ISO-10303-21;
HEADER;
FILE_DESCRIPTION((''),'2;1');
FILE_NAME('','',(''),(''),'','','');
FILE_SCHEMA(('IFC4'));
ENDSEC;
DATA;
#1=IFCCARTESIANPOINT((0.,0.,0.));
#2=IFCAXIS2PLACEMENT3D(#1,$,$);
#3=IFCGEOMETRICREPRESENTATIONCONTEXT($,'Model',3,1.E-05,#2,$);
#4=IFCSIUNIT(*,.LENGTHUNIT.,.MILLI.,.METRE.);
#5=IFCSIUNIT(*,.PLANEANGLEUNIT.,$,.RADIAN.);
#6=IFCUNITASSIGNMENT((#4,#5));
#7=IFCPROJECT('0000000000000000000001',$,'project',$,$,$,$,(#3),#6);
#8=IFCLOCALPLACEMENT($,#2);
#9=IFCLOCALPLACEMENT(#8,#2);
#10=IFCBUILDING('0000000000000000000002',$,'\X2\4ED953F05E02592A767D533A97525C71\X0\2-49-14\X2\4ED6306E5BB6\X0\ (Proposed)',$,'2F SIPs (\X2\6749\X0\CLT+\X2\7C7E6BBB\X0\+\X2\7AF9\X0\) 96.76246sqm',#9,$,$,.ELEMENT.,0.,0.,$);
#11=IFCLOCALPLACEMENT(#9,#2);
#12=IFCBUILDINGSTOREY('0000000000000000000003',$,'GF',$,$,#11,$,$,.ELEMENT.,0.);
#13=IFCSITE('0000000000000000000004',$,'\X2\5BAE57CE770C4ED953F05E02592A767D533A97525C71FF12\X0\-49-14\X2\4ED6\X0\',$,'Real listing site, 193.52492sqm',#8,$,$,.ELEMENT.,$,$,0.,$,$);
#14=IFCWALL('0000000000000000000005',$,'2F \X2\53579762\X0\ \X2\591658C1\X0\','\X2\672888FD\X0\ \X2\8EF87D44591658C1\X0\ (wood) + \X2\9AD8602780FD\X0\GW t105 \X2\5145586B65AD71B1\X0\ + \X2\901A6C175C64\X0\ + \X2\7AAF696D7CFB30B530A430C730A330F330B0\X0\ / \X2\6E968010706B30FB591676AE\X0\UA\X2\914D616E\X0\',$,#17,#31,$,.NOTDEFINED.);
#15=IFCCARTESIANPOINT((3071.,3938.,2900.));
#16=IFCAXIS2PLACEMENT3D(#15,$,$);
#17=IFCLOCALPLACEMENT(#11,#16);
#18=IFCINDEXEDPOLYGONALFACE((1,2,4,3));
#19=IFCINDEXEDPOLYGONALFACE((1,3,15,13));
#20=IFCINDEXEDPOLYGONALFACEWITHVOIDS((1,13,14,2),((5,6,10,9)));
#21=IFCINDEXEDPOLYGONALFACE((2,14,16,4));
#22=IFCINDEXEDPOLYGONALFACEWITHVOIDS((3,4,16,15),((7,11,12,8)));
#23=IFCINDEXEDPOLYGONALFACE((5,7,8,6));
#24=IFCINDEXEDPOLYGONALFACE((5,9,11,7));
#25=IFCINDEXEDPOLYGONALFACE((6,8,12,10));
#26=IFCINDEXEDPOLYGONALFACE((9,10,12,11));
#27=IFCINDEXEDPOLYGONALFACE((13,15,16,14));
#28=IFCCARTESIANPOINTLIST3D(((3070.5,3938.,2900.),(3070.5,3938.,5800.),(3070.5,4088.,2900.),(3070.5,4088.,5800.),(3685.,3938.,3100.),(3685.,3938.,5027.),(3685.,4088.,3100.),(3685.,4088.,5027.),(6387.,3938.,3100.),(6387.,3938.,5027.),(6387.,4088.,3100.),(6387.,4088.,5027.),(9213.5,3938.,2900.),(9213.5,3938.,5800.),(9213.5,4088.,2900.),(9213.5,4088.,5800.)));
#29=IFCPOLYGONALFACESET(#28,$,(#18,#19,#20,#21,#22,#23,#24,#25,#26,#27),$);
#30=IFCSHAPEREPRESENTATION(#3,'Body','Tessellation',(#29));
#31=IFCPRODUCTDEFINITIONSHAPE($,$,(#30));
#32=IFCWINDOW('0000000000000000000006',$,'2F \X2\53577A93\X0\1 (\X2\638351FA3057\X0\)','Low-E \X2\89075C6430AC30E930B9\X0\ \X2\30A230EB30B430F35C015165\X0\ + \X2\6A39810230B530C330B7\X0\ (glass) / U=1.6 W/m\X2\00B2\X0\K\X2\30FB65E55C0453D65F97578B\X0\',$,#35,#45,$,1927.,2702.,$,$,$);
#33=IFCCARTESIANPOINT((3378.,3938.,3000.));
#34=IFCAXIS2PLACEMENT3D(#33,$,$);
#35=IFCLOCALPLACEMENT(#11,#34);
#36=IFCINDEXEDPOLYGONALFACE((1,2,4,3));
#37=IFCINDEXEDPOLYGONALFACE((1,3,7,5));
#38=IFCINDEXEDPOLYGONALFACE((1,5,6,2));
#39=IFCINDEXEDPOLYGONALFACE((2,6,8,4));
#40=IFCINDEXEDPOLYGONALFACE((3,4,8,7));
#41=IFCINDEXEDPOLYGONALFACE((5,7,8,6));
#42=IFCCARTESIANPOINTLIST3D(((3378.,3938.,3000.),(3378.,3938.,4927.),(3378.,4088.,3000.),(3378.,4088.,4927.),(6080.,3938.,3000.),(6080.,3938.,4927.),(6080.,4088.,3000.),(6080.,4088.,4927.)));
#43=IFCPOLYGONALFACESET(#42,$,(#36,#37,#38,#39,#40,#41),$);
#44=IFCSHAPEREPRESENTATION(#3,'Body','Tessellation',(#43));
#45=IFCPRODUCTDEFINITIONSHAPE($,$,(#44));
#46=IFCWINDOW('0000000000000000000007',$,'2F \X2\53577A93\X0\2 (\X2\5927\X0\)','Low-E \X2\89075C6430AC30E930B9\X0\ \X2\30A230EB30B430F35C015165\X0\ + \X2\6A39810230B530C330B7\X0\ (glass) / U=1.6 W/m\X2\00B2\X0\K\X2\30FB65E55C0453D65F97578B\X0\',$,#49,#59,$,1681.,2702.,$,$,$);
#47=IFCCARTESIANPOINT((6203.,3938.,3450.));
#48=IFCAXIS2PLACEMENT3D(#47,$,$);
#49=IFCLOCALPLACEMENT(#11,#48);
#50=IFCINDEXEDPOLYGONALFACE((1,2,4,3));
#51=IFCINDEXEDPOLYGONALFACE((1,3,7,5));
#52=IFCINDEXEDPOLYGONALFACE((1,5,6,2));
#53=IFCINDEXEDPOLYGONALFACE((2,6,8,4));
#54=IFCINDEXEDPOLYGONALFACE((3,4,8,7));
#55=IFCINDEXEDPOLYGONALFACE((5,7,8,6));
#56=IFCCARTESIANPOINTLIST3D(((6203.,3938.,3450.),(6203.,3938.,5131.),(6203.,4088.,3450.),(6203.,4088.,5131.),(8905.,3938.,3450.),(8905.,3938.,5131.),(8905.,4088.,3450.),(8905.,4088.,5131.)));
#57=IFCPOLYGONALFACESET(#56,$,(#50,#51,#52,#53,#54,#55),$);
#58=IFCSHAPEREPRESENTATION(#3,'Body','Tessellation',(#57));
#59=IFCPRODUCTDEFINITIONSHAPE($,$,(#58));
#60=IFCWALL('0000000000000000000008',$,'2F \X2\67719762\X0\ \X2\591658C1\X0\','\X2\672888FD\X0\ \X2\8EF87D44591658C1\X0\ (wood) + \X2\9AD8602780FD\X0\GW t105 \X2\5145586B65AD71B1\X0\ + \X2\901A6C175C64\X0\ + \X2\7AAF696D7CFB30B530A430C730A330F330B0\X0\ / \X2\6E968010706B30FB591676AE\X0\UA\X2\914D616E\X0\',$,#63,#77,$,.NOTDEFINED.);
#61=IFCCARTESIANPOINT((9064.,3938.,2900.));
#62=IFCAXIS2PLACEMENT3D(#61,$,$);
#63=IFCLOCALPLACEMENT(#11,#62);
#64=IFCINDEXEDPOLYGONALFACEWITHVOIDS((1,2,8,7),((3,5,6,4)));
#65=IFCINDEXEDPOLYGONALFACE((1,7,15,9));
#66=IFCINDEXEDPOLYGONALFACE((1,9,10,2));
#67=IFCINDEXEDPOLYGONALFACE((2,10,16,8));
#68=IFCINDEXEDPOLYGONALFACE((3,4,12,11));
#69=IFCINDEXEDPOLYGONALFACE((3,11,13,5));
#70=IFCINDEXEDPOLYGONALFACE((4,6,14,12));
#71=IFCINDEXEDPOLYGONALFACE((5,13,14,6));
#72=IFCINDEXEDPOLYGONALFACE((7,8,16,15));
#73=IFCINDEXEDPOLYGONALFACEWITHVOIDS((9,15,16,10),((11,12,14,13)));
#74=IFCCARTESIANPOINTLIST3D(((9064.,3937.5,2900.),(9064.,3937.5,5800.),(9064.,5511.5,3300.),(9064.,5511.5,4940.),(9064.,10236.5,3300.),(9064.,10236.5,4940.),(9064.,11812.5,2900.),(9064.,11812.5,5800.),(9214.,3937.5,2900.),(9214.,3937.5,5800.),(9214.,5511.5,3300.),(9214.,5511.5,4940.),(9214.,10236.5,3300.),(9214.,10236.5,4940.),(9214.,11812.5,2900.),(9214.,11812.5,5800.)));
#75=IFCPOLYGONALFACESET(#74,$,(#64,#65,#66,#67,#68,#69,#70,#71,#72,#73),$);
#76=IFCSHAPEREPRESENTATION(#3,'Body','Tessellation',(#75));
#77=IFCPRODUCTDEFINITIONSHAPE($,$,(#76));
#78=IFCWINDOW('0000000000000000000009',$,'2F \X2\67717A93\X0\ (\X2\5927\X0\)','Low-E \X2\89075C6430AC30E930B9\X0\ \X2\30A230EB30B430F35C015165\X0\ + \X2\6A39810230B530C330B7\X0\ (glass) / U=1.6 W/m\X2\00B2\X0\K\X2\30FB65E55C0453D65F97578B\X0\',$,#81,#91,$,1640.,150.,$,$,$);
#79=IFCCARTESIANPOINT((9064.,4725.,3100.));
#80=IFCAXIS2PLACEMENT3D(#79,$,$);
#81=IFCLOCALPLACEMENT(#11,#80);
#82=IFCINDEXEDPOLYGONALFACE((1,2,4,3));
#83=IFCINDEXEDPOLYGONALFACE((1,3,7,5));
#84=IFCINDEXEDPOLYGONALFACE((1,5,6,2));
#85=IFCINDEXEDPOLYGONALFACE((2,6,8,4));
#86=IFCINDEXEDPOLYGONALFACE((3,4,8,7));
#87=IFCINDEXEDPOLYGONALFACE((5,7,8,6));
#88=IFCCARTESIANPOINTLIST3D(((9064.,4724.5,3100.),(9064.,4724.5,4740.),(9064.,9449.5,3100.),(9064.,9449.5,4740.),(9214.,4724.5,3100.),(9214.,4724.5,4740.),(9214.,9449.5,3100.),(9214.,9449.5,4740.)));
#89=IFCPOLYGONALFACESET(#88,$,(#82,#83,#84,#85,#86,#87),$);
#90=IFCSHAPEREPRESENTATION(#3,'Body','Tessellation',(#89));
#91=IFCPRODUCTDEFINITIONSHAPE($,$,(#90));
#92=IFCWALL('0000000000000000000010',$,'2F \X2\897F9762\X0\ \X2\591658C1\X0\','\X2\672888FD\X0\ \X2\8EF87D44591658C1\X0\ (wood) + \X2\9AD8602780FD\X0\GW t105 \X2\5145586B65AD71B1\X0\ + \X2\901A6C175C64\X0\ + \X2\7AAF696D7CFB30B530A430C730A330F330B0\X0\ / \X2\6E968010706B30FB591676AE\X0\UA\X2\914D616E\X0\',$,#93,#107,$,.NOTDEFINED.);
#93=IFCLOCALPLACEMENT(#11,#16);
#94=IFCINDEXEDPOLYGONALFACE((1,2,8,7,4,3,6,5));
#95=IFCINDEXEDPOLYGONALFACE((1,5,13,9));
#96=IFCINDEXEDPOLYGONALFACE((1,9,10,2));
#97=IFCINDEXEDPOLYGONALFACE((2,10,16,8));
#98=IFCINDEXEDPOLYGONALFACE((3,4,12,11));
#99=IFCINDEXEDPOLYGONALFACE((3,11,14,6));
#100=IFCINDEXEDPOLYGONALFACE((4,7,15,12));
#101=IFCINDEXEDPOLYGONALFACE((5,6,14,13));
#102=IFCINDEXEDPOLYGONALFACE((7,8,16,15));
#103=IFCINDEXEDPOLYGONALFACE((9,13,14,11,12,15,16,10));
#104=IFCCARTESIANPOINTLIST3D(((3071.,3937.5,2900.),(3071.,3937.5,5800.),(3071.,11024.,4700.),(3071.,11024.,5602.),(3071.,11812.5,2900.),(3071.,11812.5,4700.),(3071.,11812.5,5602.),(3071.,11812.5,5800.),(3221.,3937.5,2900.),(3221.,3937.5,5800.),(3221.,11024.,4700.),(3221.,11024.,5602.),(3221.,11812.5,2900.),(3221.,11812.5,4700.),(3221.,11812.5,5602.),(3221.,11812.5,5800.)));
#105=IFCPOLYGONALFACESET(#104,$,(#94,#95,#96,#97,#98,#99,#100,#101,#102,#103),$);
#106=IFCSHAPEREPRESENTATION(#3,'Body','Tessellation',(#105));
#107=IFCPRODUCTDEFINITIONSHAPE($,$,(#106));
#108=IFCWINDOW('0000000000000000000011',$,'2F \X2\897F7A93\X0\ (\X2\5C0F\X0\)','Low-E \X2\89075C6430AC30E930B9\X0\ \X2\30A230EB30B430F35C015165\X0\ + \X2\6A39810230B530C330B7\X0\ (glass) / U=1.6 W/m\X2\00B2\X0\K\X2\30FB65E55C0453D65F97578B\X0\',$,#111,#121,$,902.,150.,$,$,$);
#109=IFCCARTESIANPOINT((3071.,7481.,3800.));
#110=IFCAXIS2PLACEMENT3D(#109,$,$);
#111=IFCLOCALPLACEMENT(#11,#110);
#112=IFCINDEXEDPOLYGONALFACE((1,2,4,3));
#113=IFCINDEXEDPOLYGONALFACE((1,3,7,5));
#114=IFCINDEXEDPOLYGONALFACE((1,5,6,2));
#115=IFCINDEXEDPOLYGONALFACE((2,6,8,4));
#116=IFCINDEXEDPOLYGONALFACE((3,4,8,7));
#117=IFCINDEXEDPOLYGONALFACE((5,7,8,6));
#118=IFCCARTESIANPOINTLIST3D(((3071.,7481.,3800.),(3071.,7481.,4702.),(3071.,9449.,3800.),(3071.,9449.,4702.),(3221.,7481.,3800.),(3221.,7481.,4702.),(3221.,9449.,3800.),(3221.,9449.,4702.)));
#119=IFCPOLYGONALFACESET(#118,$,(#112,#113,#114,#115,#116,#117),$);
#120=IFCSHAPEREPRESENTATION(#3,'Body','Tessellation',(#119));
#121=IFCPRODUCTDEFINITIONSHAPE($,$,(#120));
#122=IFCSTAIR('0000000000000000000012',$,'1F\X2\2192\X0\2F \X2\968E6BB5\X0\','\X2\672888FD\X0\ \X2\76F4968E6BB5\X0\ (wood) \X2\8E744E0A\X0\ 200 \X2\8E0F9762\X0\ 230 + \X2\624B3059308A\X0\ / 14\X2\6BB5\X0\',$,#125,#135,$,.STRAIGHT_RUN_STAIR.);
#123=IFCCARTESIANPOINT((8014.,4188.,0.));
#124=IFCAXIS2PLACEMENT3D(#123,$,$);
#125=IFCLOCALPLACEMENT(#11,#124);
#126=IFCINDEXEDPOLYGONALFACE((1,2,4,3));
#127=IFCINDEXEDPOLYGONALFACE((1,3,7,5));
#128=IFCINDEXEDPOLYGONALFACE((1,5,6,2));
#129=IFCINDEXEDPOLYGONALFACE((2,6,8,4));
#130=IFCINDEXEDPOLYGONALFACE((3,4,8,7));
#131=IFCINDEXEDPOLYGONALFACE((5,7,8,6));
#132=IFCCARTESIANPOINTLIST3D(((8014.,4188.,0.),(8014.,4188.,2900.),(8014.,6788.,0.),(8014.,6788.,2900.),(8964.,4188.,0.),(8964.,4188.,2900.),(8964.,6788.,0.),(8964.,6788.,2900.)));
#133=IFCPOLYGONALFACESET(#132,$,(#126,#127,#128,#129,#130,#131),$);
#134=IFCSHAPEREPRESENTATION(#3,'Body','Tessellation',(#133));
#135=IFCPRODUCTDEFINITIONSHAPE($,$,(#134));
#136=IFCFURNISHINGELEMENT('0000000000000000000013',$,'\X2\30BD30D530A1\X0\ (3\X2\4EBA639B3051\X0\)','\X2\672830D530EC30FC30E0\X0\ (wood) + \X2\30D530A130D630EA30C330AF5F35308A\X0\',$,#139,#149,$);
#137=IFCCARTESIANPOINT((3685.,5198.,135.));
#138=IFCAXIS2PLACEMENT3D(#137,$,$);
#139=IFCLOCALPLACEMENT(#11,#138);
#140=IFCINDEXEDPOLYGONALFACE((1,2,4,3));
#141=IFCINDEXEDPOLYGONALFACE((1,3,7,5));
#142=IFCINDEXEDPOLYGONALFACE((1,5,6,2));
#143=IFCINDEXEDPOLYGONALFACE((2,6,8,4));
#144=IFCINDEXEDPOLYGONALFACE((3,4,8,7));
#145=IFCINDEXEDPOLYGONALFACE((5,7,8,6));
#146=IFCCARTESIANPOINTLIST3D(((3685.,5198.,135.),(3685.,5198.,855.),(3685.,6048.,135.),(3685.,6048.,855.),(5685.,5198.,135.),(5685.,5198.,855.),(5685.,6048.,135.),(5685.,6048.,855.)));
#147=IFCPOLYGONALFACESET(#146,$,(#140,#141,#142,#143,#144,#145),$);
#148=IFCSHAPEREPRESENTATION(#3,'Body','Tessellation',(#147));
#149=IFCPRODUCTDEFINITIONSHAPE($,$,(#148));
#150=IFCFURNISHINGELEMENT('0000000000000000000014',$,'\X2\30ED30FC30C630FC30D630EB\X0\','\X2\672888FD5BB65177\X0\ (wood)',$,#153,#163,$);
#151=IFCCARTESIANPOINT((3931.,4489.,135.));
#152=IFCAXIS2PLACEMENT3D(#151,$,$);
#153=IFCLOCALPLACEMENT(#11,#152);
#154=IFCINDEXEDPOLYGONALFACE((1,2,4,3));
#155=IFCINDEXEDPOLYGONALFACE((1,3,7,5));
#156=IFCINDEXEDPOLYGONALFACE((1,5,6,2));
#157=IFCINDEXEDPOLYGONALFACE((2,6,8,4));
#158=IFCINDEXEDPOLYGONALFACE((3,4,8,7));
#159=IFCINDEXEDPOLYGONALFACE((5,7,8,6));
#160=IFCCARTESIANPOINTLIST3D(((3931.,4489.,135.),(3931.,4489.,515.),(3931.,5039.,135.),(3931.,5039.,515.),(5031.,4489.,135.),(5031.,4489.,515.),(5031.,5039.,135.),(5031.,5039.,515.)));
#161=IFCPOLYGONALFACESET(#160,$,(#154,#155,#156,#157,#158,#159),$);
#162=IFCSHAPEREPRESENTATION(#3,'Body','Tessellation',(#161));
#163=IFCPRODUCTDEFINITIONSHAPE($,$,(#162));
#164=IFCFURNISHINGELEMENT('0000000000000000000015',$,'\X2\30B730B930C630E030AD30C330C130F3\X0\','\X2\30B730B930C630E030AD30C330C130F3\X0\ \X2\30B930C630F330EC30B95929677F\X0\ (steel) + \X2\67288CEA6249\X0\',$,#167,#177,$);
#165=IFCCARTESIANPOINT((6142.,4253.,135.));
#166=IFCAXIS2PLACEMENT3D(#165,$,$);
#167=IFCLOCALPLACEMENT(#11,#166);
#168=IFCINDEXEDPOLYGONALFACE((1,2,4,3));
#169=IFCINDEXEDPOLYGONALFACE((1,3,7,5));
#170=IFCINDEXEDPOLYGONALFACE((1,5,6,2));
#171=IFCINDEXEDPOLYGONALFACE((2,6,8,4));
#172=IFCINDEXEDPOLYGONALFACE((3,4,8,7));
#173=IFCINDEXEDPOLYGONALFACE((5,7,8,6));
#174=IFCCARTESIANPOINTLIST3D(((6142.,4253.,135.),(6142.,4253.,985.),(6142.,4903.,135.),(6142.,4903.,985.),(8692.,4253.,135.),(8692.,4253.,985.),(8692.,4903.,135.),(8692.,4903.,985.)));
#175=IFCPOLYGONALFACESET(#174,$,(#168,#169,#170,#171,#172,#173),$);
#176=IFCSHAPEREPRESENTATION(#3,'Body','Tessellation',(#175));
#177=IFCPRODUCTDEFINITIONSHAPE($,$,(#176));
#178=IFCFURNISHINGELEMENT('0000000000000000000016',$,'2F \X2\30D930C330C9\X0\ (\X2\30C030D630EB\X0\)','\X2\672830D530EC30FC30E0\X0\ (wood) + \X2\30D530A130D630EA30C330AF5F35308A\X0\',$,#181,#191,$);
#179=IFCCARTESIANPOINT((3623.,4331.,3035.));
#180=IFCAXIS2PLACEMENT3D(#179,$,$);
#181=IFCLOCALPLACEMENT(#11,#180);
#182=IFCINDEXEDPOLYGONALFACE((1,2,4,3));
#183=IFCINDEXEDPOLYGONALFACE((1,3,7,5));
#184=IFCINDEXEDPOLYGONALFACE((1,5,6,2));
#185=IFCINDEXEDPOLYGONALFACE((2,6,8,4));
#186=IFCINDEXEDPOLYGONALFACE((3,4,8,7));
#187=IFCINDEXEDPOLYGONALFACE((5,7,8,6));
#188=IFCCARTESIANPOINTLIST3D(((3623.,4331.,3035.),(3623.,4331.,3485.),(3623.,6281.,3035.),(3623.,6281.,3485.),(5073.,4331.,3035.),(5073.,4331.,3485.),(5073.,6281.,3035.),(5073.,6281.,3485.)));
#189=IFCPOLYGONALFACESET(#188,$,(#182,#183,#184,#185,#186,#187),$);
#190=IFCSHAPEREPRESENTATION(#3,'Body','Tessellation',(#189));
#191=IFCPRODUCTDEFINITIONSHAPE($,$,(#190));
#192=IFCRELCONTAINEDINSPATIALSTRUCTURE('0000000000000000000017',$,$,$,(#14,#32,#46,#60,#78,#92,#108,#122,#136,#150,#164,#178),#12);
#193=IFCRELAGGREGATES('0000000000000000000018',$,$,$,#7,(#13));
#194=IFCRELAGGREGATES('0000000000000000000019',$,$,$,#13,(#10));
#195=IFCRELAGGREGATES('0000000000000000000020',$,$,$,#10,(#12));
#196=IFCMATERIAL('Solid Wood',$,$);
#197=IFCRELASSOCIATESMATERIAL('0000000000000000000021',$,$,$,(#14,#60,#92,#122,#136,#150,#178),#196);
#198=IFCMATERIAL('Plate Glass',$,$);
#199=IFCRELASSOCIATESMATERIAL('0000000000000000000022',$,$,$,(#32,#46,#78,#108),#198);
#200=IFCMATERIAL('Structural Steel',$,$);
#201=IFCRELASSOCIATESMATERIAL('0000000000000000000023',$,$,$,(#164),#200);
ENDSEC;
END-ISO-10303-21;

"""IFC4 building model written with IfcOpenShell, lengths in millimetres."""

from ifc_helpers import new_model, si_unit, frame, frame_2d, origin, place, context, project, spatial, rectangle, extrude, material, element, fill, save


model = new_model("IFC4")

# Units and contexts
model_context = context("Model", 3, precision=1e-05, world=origin())
ifc_project = project(units=[si_unit("LENGTHUNIT", "METRE", prefix="MILLI"), si_unit("PLANEANGLEUNIT", "RADIAN")], contexts=[model_context])

# Site, building, storey
site_placement = place(None, origin())
site = spatial("IfcSite", under=ifc_project, at=site_placement, Name="宮城県仙台市太白区青山２-49-14他", ObjectType="Real listing site, 193.52492sqm", CompositionType="ELEMENT", RefElevation=0.0)
building_placement = place(site_placement, origin())
building = spatial("IfcBuilding", under=site, at=building_placement, Name="仙台市太白区青山2-49-14他の家 (Proposed)", ObjectType="2F SIPs (杉CLT+籾殻+竹) 96.76246sqm", CompositionType="ELEMENT", ElevationOfRefHeight=0.0, ElevationOfTerrain=0.0)
storey_placement = place(building_placement, origin())
storey = spatial("IfcBuildingStorey", under=building, at=storey_placement, Name="GF", CompositionType="ELEMENT", Elevation=0.0)

# Shared definitions
ifc_material_1 = material(Name="Solid Wood")

# Shared definitions
ifc_material_2 = material(Name="Plate Glass")

# Wall, openings, windows
wall_1_placement = place(storey_placement, frame((3071.0, 3938.0, 2900.0)))
wall_1 = element("IfcWall", 1, at=wall_1_placement, inside=storey, material=ifc_material_1, Name="2F 南面 外壁", Description="木製 軸組外壁 (wood) + 高性能GW t105 充填断熱 + 通気層 + 窯業系サイディング / 準耐火・外皮UA配慮", PredefinedType="NOTDEFINED", context=model_context, shape_type="SweptSolid", body=[
    extrude(rectangle(XDim=6143.0, YDim=150.0, at=frame_2d((3071.0, 75.0))), frame((3071.0, 3938.0, 2900.0)), (0.0, 0.0, 1.0), 2900.0),
])
opening_1_placement = place(storey_placement, frame((3378.0, 3938.0, 3000.0)))
opening_1 = element("IfcOpeningElement", 2, at=opening_1_placement, cuts=wall_1, PredefinedType="NOTDEFINED", context=model_context, shape_type="SweptSolid", body=[
    extrude(rectangle(XDim=2702.0, YDim=150.0, at=frame_2d((1351.0, 75.0))), frame((3378.0, 3938.0, 3000.0)), (0.0, 0.0, 1.0), 1927.0),
])
opening_2_placement = place(storey_placement, frame((6203.0, 3938.0, 3450.0)))
opening_2 = element("IfcOpeningElement", 3, at=opening_2_placement, cuts=wall_1, PredefinedType="NOTDEFINED", context=model_context, shape_type="SweptSolid", body=[
    extrude(rectangle(XDim=2702.0, YDim=150.0, at=frame_2d((1351.0, 75.0))), frame((6203.0, 3938.0, 3450.0)), (0.0, 0.0, 1.0), 1681.0),
])
window_1_placement = place(storey_placement, frame((3378.0, 3938.0, 3000.0)))
window_1 = element("IfcWindow", 4, at=window_1_placement, inside=storey, material=ifc_material_2, Name="2F 南窓1 (掃出し)", Description="Low-E 複層ガラス アルゴン封入 + 樹脂サッシ (glass) / U=1.6 W/m²K・日射取得型", OverallHeight=1927.0, OverallWidth=2702.0, context=model_context, shape_type="SweptSolid", body=[
    extrude(rectangle(XDim=2702.0, YDim=150.0, at=frame_2d((1351.0, 75.0))), frame((3378.0, 3938.0, 3000.0)), (0.0, 0.0, 1.0), 1927.0),
])
fill(opening_1, window_1)
window_2_placement = place(storey_placement, frame((6203.0, 3938.0, 3450.0)))
window_2 = element("IfcWindow", 5, at=window_2_placement, inside=storey, material=ifc_material_2, Name="2F 南窓2 (大)", Description="Low-E 複層ガラス アルゴン封入 + 樹脂サッシ (glass) / U=1.6 W/m²K・日射取得型", OverallHeight=1681.0, OverallWidth=2702.0, context=model_context, shape_type="SweptSolid", body=[
    extrude(rectangle(XDim=2702.0, YDim=150.0, at=frame_2d((1351.0, 75.0))), frame((6203.0, 3938.0, 3450.0)), (0.0, 0.0, 1.0), 1681.0),
])
fill(opening_2, window_2)

# Walls, openings, windows
wall_2_placement = place(storey_placement, frame((9064.0, 3938.0, 2900.0)))
wall_2 = element("IfcWall", 6, at=wall_2_placement, inside=storey, material=ifc_material_1, Name="2F 東面 外壁", Description="木製 軸組外壁 (wood) + 高性能GW t105 充填断熱 + 通気層 + 窯業系サイディング / 準耐火・外皮UA配慮", PredefinedType="NOTDEFINED", context=model_context, shape_type="SweptSolid", body=[
    extrude(rectangle(XDim=150.0, YDim=7875.0, at=frame_2d((75.0, 3937.0))), frame((9064.0, 3938.0, 2900.0)), (0.0, 0.0, 1.0), 2900.0),
])
opening_3_placement = place(storey_placement, frame((9064.0, 4725.0, 3100.0)))
opening_3 = element("IfcOpeningElement", 7, at=opening_3_placement, cuts=wall_2, PredefinedType="NOTDEFINED", context=model_context, shape_type="SweptSolid", body=[
    extrude(rectangle(XDim=150.0, YDim=4725.0, at=frame_2d((75.0, 2362.0))), frame((9064.0, 4725.0, 3100.0)), (0.0, 0.0, 1.0), 1640.0),
])
window_3_placement = place(storey_placement, frame((9064.0, 4725.0, 3100.0)))
window_3 = element("IfcWindow", 8, at=window_3_placement, inside=storey, material=ifc_material_2, Name="2F 東窓 (大)", Description="Low-E 複層ガラス アルゴン封入 + 樹脂サッシ (glass) / U=1.6 W/m²K・日射取得型", OverallHeight=1640.0, OverallWidth=150.0, context=model_context, shape_type="SweptSolid", body=[
    extrude(rectangle(XDim=150.0, YDim=4725.0, at=frame_2d((75.0, 2362.0))), frame((9064.0, 4725.0, 3100.0)), (0.0, 0.0, 1.0), 1640.0),
])
fill(opening_3, window_3)
wall_3_placement = place(storey_placement, frame((3071.0, 3938.0, 2900.0)))
wall_3 = element("IfcWall", 9, at=wall_3_placement, inside=storey, material=ifc_material_1, Name="2F 西面 外壁", Description="木製 軸組外壁 (wood) + 高性能GW t105 充填断熱 + 通気層 + 窯業系サイディング / 準耐火・外皮UA配慮", PredefinedType="NOTDEFINED", context=model_context, shape_type="SweptSolid", body=[
    extrude(rectangle(XDim=150.0, YDim=7875.0, at=frame_2d((75.0, 3937.0))), frame((3071.0, 3938.0, 2900.0)), (0.0, 0.0, 1.0), 2900.0),
])
opening_4_placement = place(storey_placement, frame((3071.0, 7481.0, 3800.0)))
opening_4 = element("IfcOpeningElement", 10, at=opening_4_placement, cuts=wall_3, PredefinedType="NOTDEFINED", context=model_context, shape_type="SweptSolid", body=[
    extrude(rectangle(XDim=150.0, YDim=1968.0, at=frame_2d((75.0, 984.0))), frame((3071.0, 7481.0, 3800.0)), (0.0, 0.0, 1.0), 902.0),
])
window_4_placement = place(storey_placement, frame((3071.0, 7481.0, 3800.0)))
window_4 = element("IfcWindow", 11, at=window_4_placement, inside=storey, material=ifc_material_2, Name="2F 西窓 (小)", Description="Low-E 複層ガラス アルゴン封入 + 樹脂サッシ (glass) / U=1.6 W/m²K・日射取得型", OverallHeight=902.0, OverallWidth=150.0, context=model_context, shape_type="SweptSolid", body=[
    extrude(rectangle(XDim=150.0, YDim=1968.0, at=frame_2d((75.0, 984.0))), frame((3071.0, 7481.0, 3800.0)), (0.0, 0.0, 1.0), 902.0),
])
fill(opening_4, window_4)

# Stair
stair_placement = place(storey_placement, frame((8014.0, 4188.0, 0.0)))
element("IfcStair", 12, at=stair_placement, inside=storey, material=ifc_material_1, Name="1F→2F 階段", Description="木製 直階段 (wood) 蹴上 200 踏面 230 + 手すり / 14段", PredefinedType="STRAIGHT_RUN_STAIR", context=model_context, shape_type="SweptSolid", body=[
    extrude(rectangle(XDim=950.0, YDim=2600.0, at=frame_2d((475.0, 1300.0))), frame((8014.0, 4188.0, 0.0)), (0.0, 0.0, 1.0), 2900.0),
])

# Shared definitions
ifc_material_3 = material(Name="Structural Steel")

# Furnishing elements
furnishing_1_placement = place(storey_placement, frame((3685.0, 5198.0, 135.0)))
element("IfcFurnishingElement", 13, at=furnishing_1_placement, inside=storey, material=ifc_material_1, Name="ソファ (3人掛け)", Description="木フレーム (wood) + ファブリック張り", context=model_context, shape_type="SweptSolid", body=[
    extrude(rectangle(XDim=2000.0, YDim=850.0, at=frame_2d((1000.0, 425.0))), frame((3685.0, 5198.0, 135.0)), (0.0, 0.0, 1.0), 720.0),
])
furnishing_2_placement = place(storey_placement, frame((3931.0, 4489.0, 135.0)))
element("IfcFurnishingElement", 14, at=furnishing_2_placement, inside=storey, material=ifc_material_1, Name="ローテーブル", Description="木製家具 (wood)", context=model_context, shape_type="SweptSolid", body=[
    extrude(rectangle(XDim=1100.0, YDim=550.0, at=frame_2d((550.0, 275.0))), frame((3931.0, 4489.0, 135.0)), (0.0, 0.0, 1.0), 380.0),
])
furnishing_3_placement = place(storey_placement, frame((6142.0, 4253.0, 135.0)))
element("IfcFurnishingElement", 15, at=furnishing_3_placement, inside=storey, material=ifc_material_3, Name="システムキッチン", Description="システムキッチン ステンレス天板 (steel) + 木質扉", context=model_context, shape_type="SweptSolid", body=[
    extrude(rectangle(XDim=2550.0, YDim=650.0, at=frame_2d((1275.0, 325.0))), frame((6142.0, 4253.0, 135.0)), (0.0, 0.0, 1.0), 850.0),
])
furnishing_4_placement = place(storey_placement, frame((3623.0, 4331.0, 3035.0)))
element("IfcFurnishingElement", 16, at=furnishing_4_placement, inside=storey, material=ifc_material_1, Name="2F ベッド (ダブル)", Description="木フレーム (wood) + ファブリック張り", context=model_context, shape_type="SweptSolid", body=[
    extrude(rectangle(XDim=1450.0, YDim=1950.0, at=frame_2d((725.0, 975.0))), frame((3623.0, 4331.0, 3035.0)), (0.0, 0.0, 1.0), 450.0),
])

save(model, "model.ifc")
